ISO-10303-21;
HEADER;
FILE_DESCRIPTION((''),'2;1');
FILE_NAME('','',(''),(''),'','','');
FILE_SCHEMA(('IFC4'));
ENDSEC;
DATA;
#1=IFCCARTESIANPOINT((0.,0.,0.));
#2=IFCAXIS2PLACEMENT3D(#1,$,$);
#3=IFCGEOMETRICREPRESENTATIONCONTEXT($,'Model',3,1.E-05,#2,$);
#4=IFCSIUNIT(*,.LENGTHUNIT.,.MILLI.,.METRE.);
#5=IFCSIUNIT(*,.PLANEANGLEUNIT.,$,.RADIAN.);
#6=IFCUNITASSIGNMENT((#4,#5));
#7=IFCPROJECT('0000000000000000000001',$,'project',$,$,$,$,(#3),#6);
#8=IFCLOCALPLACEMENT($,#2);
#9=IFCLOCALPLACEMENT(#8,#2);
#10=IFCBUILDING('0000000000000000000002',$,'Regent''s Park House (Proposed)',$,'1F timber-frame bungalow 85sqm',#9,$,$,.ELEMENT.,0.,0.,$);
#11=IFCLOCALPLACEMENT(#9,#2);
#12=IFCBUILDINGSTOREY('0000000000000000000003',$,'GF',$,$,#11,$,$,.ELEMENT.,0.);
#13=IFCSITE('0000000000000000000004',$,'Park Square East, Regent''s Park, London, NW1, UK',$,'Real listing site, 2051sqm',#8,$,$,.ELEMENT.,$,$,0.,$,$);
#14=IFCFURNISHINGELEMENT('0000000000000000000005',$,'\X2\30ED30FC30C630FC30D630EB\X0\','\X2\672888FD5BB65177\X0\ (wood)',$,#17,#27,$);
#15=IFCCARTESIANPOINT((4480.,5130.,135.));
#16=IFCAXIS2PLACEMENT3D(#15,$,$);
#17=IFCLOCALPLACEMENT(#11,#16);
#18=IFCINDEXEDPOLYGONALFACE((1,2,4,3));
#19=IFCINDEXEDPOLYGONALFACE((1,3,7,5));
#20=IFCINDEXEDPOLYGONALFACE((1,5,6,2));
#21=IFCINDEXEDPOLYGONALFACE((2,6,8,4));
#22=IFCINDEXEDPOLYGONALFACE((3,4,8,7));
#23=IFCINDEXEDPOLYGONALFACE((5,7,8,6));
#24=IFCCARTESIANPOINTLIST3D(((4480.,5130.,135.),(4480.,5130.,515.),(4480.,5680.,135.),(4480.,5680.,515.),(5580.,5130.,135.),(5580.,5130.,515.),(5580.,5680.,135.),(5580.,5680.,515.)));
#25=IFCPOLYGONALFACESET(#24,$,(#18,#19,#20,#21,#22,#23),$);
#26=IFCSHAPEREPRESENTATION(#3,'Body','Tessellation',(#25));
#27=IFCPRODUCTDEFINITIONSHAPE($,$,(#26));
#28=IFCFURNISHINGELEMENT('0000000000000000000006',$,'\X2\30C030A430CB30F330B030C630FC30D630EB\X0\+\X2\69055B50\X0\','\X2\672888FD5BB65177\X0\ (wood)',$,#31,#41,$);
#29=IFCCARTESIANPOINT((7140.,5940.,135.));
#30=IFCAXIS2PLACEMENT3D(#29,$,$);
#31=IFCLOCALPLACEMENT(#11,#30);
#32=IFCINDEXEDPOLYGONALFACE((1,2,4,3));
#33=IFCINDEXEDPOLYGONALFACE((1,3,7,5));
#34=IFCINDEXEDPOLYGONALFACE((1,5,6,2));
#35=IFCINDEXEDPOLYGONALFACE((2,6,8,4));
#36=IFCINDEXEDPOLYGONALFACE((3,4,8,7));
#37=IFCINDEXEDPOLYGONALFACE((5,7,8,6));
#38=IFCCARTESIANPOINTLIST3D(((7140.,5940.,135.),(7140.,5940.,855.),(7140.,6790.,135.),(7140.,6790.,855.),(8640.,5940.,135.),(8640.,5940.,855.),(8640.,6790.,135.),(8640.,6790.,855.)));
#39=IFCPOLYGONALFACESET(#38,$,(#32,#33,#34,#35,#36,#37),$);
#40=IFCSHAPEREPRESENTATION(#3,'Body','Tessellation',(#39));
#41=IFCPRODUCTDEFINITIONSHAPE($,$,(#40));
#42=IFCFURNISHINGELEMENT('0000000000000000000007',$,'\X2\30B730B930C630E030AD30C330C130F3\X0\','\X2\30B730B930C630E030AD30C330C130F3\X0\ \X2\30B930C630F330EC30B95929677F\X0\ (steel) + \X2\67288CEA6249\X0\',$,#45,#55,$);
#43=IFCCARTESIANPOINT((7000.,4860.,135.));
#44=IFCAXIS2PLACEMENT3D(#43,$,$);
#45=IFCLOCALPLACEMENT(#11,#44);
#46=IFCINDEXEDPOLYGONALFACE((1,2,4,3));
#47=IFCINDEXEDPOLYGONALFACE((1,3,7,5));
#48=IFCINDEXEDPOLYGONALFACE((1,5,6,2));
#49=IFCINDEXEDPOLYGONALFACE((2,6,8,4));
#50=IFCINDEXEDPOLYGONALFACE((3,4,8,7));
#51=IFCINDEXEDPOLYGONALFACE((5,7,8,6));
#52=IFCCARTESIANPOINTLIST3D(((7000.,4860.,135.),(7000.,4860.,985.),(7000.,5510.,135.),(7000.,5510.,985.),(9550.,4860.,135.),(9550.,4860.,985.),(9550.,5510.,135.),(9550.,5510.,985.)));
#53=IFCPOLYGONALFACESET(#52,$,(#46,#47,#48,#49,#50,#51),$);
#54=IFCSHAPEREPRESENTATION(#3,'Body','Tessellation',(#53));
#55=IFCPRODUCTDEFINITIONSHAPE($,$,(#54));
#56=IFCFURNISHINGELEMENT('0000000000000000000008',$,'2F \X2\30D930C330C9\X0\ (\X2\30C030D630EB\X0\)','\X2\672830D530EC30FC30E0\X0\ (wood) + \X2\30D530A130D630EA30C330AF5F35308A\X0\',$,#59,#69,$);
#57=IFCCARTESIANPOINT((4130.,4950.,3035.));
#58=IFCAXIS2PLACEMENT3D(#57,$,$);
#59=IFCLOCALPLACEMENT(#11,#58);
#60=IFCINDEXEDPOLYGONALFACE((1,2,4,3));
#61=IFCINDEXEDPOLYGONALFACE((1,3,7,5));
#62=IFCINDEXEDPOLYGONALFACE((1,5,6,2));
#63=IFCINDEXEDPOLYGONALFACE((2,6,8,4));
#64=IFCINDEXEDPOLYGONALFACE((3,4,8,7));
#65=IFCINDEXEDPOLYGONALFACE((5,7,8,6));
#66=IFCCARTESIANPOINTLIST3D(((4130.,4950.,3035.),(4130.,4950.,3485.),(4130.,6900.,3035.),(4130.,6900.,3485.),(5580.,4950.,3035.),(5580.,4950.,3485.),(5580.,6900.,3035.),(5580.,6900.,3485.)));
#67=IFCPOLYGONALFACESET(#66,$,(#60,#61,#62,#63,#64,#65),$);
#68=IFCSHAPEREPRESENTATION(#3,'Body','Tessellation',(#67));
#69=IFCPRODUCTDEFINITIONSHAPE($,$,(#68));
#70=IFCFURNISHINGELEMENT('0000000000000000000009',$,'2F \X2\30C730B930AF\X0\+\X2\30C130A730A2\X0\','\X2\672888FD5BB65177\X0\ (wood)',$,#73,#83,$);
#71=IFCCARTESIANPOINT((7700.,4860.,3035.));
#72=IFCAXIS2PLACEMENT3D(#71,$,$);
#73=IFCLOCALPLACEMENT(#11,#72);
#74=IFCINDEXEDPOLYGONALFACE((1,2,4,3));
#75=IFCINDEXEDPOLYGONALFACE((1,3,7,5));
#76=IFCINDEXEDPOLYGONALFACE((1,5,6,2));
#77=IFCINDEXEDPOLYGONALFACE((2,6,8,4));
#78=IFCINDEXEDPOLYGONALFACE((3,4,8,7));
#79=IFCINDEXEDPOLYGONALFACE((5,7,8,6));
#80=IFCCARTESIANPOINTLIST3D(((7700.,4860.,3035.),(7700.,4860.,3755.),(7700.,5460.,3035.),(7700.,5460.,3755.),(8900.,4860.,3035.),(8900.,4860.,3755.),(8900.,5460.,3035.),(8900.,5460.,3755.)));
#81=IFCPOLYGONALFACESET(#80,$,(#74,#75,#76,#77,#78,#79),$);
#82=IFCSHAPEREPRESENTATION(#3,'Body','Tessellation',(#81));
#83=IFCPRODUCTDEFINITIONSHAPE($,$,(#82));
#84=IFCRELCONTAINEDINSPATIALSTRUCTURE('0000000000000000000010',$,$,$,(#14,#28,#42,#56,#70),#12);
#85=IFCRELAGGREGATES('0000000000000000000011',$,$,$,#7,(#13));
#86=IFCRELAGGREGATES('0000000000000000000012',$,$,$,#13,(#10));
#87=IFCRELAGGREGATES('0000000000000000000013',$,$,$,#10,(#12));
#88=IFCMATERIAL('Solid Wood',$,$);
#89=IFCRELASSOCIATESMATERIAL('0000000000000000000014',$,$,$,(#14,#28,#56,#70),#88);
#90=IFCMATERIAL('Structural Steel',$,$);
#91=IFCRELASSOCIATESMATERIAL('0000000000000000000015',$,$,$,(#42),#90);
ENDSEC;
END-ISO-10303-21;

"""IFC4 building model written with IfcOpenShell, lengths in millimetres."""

from ifc_helpers import new_model, si_unit, frame, frame_2d, origin, place, context, project, spatial, rectangle, extrude, material, element, save


model = new_model("IFC4")

# Units and contexts
model_context = context("Model", 3, precision=1e-05, world=origin())
ifc_project = project(units=[si_unit("LENGTHUNIT", "METRE", prefix="MILLI"), si_unit("PLANEANGLEUNIT", "RADIAN")], contexts=[model_context])

# Site, building, storey
site_placement = place(None, origin())
site = spatial("IfcSite", under=ifc_project, at=site_placement, Name="Park Square East, Regent's Park, London, NW1, UK", ObjectType="Real listing site, 2051sqm", CompositionType="ELEMENT", RefElevation=0.0)
building_placement = place(site_placement, origin())
building = spatial("IfcBuilding", under=site, at=building_placement, Name="Regent's Park House (Proposed)", ObjectType="1F timber-frame bungalow 85sqm", CompositionType="ELEMENT", ElevationOfRefHeight=0.0, ElevationOfTerrain=0.0)
storey_placement = place(building_placement, origin())
storey = spatial("IfcBuildingStorey", under=building, at=storey_placement, Name="GF", CompositionType="ELEMENT", Elevation=0.0)

# Shared definitions
ifc_material_1 = material(Name="Solid Wood")

# Shared definitions
ifc_material_2 = material(Name="Structural Steel")

# Furnishing elements
furnishing_1_placement = place(storey_placement, frame((4480.0, 5130.0, 135.0)))
element("IfcFurnishingElement", 1, at=furnishing_1_placement, inside=storey, material=ifc_material_1, Name="ローテーブル", Description="木製家具 (wood)", context=model_context, shape_type="SweptSolid", body=[
    extrude(rectangle(XDim=1100.0, YDim=550.0, at=frame_2d((550.0, 275.0))), frame((4480.0, 5130.0, 135.0)), (0.0, 0.0, 1.0), 380.0),
])
furnishing_2_placement = place(storey_placement, frame((7140.0, 5940.0, 135.0)))
element("IfcFurnishingElement", 2, at=furnishing_2_placement, inside=storey, material=ifc_material_1, Name="ダイニングテーブル+椅子", Description="木製家具 (wood)", context=model_context, shape_type="SweptSolid", body=[
    extrude(rectangle(XDim=1500.0, YDim=850.0, at=frame_2d((750.0, 425.0))), frame((7140.0, 5940.0, 135.0)), (0.0, 0.0, 1.0), 720.0),
])
furnishing_3_placement = place(storey_placement, frame((7000.0, 4860.0, 135.0)))
element("IfcFurnishingElement", 3, at=furnishing_3_placement, inside=storey, material=ifc_material_2, Name="システムキッチン", Description="システムキッチン ステンレス天板 (steel) + 木質扉", context=model_context, shape_type="SweptSolid", body=[
    extrude(rectangle(XDim=2550.0, YDim=650.0, at=frame_2d((1275.0, 325.0))), frame((7000.0, 4860.0, 135.0)), (0.0, 0.0, 1.0), 850.0),
])
furnishing_4_placement = place(storey_placement, frame((4130.0, 4950.0, 3035.0)))
element("IfcFurnishingElement", 4, at=furnishing_4_placement, inside=storey, material=ifc_material_1, Name="2F ベッド (ダブル)", Description="木フレーム (wood) + ファブリック張り", context=model_context, shape_type="SweptSolid", body=[
    extrude(rectangle(XDim=1450.0, YDim=1950.0, at=frame_2d((725.0, 975.0))), frame((4130.0, 4950.0, 3035.0)), (0.0, 0.0, 1.0), 450.0),
])
furnishing_5_placement = place(storey_placement, frame((7700.0, 4860.0, 3035.0)))
element("IfcFurnishingElement", 5, at=furnishing_5_placement, inside=storey, material=ifc_material_1, Name="2F デスク+チェア", Description="木製家具 (wood)", context=model_context, shape_type="SweptSolid", body=[
    extrude(rectangle(XDim=1200.0, YDim=600.0, at=frame_2d((600.0, 300.0))), frame((7700.0, 4860.0, 3035.0)), (0.0, 0.0, 1.0), 720.0),
])

save(model, "model.ifc")
